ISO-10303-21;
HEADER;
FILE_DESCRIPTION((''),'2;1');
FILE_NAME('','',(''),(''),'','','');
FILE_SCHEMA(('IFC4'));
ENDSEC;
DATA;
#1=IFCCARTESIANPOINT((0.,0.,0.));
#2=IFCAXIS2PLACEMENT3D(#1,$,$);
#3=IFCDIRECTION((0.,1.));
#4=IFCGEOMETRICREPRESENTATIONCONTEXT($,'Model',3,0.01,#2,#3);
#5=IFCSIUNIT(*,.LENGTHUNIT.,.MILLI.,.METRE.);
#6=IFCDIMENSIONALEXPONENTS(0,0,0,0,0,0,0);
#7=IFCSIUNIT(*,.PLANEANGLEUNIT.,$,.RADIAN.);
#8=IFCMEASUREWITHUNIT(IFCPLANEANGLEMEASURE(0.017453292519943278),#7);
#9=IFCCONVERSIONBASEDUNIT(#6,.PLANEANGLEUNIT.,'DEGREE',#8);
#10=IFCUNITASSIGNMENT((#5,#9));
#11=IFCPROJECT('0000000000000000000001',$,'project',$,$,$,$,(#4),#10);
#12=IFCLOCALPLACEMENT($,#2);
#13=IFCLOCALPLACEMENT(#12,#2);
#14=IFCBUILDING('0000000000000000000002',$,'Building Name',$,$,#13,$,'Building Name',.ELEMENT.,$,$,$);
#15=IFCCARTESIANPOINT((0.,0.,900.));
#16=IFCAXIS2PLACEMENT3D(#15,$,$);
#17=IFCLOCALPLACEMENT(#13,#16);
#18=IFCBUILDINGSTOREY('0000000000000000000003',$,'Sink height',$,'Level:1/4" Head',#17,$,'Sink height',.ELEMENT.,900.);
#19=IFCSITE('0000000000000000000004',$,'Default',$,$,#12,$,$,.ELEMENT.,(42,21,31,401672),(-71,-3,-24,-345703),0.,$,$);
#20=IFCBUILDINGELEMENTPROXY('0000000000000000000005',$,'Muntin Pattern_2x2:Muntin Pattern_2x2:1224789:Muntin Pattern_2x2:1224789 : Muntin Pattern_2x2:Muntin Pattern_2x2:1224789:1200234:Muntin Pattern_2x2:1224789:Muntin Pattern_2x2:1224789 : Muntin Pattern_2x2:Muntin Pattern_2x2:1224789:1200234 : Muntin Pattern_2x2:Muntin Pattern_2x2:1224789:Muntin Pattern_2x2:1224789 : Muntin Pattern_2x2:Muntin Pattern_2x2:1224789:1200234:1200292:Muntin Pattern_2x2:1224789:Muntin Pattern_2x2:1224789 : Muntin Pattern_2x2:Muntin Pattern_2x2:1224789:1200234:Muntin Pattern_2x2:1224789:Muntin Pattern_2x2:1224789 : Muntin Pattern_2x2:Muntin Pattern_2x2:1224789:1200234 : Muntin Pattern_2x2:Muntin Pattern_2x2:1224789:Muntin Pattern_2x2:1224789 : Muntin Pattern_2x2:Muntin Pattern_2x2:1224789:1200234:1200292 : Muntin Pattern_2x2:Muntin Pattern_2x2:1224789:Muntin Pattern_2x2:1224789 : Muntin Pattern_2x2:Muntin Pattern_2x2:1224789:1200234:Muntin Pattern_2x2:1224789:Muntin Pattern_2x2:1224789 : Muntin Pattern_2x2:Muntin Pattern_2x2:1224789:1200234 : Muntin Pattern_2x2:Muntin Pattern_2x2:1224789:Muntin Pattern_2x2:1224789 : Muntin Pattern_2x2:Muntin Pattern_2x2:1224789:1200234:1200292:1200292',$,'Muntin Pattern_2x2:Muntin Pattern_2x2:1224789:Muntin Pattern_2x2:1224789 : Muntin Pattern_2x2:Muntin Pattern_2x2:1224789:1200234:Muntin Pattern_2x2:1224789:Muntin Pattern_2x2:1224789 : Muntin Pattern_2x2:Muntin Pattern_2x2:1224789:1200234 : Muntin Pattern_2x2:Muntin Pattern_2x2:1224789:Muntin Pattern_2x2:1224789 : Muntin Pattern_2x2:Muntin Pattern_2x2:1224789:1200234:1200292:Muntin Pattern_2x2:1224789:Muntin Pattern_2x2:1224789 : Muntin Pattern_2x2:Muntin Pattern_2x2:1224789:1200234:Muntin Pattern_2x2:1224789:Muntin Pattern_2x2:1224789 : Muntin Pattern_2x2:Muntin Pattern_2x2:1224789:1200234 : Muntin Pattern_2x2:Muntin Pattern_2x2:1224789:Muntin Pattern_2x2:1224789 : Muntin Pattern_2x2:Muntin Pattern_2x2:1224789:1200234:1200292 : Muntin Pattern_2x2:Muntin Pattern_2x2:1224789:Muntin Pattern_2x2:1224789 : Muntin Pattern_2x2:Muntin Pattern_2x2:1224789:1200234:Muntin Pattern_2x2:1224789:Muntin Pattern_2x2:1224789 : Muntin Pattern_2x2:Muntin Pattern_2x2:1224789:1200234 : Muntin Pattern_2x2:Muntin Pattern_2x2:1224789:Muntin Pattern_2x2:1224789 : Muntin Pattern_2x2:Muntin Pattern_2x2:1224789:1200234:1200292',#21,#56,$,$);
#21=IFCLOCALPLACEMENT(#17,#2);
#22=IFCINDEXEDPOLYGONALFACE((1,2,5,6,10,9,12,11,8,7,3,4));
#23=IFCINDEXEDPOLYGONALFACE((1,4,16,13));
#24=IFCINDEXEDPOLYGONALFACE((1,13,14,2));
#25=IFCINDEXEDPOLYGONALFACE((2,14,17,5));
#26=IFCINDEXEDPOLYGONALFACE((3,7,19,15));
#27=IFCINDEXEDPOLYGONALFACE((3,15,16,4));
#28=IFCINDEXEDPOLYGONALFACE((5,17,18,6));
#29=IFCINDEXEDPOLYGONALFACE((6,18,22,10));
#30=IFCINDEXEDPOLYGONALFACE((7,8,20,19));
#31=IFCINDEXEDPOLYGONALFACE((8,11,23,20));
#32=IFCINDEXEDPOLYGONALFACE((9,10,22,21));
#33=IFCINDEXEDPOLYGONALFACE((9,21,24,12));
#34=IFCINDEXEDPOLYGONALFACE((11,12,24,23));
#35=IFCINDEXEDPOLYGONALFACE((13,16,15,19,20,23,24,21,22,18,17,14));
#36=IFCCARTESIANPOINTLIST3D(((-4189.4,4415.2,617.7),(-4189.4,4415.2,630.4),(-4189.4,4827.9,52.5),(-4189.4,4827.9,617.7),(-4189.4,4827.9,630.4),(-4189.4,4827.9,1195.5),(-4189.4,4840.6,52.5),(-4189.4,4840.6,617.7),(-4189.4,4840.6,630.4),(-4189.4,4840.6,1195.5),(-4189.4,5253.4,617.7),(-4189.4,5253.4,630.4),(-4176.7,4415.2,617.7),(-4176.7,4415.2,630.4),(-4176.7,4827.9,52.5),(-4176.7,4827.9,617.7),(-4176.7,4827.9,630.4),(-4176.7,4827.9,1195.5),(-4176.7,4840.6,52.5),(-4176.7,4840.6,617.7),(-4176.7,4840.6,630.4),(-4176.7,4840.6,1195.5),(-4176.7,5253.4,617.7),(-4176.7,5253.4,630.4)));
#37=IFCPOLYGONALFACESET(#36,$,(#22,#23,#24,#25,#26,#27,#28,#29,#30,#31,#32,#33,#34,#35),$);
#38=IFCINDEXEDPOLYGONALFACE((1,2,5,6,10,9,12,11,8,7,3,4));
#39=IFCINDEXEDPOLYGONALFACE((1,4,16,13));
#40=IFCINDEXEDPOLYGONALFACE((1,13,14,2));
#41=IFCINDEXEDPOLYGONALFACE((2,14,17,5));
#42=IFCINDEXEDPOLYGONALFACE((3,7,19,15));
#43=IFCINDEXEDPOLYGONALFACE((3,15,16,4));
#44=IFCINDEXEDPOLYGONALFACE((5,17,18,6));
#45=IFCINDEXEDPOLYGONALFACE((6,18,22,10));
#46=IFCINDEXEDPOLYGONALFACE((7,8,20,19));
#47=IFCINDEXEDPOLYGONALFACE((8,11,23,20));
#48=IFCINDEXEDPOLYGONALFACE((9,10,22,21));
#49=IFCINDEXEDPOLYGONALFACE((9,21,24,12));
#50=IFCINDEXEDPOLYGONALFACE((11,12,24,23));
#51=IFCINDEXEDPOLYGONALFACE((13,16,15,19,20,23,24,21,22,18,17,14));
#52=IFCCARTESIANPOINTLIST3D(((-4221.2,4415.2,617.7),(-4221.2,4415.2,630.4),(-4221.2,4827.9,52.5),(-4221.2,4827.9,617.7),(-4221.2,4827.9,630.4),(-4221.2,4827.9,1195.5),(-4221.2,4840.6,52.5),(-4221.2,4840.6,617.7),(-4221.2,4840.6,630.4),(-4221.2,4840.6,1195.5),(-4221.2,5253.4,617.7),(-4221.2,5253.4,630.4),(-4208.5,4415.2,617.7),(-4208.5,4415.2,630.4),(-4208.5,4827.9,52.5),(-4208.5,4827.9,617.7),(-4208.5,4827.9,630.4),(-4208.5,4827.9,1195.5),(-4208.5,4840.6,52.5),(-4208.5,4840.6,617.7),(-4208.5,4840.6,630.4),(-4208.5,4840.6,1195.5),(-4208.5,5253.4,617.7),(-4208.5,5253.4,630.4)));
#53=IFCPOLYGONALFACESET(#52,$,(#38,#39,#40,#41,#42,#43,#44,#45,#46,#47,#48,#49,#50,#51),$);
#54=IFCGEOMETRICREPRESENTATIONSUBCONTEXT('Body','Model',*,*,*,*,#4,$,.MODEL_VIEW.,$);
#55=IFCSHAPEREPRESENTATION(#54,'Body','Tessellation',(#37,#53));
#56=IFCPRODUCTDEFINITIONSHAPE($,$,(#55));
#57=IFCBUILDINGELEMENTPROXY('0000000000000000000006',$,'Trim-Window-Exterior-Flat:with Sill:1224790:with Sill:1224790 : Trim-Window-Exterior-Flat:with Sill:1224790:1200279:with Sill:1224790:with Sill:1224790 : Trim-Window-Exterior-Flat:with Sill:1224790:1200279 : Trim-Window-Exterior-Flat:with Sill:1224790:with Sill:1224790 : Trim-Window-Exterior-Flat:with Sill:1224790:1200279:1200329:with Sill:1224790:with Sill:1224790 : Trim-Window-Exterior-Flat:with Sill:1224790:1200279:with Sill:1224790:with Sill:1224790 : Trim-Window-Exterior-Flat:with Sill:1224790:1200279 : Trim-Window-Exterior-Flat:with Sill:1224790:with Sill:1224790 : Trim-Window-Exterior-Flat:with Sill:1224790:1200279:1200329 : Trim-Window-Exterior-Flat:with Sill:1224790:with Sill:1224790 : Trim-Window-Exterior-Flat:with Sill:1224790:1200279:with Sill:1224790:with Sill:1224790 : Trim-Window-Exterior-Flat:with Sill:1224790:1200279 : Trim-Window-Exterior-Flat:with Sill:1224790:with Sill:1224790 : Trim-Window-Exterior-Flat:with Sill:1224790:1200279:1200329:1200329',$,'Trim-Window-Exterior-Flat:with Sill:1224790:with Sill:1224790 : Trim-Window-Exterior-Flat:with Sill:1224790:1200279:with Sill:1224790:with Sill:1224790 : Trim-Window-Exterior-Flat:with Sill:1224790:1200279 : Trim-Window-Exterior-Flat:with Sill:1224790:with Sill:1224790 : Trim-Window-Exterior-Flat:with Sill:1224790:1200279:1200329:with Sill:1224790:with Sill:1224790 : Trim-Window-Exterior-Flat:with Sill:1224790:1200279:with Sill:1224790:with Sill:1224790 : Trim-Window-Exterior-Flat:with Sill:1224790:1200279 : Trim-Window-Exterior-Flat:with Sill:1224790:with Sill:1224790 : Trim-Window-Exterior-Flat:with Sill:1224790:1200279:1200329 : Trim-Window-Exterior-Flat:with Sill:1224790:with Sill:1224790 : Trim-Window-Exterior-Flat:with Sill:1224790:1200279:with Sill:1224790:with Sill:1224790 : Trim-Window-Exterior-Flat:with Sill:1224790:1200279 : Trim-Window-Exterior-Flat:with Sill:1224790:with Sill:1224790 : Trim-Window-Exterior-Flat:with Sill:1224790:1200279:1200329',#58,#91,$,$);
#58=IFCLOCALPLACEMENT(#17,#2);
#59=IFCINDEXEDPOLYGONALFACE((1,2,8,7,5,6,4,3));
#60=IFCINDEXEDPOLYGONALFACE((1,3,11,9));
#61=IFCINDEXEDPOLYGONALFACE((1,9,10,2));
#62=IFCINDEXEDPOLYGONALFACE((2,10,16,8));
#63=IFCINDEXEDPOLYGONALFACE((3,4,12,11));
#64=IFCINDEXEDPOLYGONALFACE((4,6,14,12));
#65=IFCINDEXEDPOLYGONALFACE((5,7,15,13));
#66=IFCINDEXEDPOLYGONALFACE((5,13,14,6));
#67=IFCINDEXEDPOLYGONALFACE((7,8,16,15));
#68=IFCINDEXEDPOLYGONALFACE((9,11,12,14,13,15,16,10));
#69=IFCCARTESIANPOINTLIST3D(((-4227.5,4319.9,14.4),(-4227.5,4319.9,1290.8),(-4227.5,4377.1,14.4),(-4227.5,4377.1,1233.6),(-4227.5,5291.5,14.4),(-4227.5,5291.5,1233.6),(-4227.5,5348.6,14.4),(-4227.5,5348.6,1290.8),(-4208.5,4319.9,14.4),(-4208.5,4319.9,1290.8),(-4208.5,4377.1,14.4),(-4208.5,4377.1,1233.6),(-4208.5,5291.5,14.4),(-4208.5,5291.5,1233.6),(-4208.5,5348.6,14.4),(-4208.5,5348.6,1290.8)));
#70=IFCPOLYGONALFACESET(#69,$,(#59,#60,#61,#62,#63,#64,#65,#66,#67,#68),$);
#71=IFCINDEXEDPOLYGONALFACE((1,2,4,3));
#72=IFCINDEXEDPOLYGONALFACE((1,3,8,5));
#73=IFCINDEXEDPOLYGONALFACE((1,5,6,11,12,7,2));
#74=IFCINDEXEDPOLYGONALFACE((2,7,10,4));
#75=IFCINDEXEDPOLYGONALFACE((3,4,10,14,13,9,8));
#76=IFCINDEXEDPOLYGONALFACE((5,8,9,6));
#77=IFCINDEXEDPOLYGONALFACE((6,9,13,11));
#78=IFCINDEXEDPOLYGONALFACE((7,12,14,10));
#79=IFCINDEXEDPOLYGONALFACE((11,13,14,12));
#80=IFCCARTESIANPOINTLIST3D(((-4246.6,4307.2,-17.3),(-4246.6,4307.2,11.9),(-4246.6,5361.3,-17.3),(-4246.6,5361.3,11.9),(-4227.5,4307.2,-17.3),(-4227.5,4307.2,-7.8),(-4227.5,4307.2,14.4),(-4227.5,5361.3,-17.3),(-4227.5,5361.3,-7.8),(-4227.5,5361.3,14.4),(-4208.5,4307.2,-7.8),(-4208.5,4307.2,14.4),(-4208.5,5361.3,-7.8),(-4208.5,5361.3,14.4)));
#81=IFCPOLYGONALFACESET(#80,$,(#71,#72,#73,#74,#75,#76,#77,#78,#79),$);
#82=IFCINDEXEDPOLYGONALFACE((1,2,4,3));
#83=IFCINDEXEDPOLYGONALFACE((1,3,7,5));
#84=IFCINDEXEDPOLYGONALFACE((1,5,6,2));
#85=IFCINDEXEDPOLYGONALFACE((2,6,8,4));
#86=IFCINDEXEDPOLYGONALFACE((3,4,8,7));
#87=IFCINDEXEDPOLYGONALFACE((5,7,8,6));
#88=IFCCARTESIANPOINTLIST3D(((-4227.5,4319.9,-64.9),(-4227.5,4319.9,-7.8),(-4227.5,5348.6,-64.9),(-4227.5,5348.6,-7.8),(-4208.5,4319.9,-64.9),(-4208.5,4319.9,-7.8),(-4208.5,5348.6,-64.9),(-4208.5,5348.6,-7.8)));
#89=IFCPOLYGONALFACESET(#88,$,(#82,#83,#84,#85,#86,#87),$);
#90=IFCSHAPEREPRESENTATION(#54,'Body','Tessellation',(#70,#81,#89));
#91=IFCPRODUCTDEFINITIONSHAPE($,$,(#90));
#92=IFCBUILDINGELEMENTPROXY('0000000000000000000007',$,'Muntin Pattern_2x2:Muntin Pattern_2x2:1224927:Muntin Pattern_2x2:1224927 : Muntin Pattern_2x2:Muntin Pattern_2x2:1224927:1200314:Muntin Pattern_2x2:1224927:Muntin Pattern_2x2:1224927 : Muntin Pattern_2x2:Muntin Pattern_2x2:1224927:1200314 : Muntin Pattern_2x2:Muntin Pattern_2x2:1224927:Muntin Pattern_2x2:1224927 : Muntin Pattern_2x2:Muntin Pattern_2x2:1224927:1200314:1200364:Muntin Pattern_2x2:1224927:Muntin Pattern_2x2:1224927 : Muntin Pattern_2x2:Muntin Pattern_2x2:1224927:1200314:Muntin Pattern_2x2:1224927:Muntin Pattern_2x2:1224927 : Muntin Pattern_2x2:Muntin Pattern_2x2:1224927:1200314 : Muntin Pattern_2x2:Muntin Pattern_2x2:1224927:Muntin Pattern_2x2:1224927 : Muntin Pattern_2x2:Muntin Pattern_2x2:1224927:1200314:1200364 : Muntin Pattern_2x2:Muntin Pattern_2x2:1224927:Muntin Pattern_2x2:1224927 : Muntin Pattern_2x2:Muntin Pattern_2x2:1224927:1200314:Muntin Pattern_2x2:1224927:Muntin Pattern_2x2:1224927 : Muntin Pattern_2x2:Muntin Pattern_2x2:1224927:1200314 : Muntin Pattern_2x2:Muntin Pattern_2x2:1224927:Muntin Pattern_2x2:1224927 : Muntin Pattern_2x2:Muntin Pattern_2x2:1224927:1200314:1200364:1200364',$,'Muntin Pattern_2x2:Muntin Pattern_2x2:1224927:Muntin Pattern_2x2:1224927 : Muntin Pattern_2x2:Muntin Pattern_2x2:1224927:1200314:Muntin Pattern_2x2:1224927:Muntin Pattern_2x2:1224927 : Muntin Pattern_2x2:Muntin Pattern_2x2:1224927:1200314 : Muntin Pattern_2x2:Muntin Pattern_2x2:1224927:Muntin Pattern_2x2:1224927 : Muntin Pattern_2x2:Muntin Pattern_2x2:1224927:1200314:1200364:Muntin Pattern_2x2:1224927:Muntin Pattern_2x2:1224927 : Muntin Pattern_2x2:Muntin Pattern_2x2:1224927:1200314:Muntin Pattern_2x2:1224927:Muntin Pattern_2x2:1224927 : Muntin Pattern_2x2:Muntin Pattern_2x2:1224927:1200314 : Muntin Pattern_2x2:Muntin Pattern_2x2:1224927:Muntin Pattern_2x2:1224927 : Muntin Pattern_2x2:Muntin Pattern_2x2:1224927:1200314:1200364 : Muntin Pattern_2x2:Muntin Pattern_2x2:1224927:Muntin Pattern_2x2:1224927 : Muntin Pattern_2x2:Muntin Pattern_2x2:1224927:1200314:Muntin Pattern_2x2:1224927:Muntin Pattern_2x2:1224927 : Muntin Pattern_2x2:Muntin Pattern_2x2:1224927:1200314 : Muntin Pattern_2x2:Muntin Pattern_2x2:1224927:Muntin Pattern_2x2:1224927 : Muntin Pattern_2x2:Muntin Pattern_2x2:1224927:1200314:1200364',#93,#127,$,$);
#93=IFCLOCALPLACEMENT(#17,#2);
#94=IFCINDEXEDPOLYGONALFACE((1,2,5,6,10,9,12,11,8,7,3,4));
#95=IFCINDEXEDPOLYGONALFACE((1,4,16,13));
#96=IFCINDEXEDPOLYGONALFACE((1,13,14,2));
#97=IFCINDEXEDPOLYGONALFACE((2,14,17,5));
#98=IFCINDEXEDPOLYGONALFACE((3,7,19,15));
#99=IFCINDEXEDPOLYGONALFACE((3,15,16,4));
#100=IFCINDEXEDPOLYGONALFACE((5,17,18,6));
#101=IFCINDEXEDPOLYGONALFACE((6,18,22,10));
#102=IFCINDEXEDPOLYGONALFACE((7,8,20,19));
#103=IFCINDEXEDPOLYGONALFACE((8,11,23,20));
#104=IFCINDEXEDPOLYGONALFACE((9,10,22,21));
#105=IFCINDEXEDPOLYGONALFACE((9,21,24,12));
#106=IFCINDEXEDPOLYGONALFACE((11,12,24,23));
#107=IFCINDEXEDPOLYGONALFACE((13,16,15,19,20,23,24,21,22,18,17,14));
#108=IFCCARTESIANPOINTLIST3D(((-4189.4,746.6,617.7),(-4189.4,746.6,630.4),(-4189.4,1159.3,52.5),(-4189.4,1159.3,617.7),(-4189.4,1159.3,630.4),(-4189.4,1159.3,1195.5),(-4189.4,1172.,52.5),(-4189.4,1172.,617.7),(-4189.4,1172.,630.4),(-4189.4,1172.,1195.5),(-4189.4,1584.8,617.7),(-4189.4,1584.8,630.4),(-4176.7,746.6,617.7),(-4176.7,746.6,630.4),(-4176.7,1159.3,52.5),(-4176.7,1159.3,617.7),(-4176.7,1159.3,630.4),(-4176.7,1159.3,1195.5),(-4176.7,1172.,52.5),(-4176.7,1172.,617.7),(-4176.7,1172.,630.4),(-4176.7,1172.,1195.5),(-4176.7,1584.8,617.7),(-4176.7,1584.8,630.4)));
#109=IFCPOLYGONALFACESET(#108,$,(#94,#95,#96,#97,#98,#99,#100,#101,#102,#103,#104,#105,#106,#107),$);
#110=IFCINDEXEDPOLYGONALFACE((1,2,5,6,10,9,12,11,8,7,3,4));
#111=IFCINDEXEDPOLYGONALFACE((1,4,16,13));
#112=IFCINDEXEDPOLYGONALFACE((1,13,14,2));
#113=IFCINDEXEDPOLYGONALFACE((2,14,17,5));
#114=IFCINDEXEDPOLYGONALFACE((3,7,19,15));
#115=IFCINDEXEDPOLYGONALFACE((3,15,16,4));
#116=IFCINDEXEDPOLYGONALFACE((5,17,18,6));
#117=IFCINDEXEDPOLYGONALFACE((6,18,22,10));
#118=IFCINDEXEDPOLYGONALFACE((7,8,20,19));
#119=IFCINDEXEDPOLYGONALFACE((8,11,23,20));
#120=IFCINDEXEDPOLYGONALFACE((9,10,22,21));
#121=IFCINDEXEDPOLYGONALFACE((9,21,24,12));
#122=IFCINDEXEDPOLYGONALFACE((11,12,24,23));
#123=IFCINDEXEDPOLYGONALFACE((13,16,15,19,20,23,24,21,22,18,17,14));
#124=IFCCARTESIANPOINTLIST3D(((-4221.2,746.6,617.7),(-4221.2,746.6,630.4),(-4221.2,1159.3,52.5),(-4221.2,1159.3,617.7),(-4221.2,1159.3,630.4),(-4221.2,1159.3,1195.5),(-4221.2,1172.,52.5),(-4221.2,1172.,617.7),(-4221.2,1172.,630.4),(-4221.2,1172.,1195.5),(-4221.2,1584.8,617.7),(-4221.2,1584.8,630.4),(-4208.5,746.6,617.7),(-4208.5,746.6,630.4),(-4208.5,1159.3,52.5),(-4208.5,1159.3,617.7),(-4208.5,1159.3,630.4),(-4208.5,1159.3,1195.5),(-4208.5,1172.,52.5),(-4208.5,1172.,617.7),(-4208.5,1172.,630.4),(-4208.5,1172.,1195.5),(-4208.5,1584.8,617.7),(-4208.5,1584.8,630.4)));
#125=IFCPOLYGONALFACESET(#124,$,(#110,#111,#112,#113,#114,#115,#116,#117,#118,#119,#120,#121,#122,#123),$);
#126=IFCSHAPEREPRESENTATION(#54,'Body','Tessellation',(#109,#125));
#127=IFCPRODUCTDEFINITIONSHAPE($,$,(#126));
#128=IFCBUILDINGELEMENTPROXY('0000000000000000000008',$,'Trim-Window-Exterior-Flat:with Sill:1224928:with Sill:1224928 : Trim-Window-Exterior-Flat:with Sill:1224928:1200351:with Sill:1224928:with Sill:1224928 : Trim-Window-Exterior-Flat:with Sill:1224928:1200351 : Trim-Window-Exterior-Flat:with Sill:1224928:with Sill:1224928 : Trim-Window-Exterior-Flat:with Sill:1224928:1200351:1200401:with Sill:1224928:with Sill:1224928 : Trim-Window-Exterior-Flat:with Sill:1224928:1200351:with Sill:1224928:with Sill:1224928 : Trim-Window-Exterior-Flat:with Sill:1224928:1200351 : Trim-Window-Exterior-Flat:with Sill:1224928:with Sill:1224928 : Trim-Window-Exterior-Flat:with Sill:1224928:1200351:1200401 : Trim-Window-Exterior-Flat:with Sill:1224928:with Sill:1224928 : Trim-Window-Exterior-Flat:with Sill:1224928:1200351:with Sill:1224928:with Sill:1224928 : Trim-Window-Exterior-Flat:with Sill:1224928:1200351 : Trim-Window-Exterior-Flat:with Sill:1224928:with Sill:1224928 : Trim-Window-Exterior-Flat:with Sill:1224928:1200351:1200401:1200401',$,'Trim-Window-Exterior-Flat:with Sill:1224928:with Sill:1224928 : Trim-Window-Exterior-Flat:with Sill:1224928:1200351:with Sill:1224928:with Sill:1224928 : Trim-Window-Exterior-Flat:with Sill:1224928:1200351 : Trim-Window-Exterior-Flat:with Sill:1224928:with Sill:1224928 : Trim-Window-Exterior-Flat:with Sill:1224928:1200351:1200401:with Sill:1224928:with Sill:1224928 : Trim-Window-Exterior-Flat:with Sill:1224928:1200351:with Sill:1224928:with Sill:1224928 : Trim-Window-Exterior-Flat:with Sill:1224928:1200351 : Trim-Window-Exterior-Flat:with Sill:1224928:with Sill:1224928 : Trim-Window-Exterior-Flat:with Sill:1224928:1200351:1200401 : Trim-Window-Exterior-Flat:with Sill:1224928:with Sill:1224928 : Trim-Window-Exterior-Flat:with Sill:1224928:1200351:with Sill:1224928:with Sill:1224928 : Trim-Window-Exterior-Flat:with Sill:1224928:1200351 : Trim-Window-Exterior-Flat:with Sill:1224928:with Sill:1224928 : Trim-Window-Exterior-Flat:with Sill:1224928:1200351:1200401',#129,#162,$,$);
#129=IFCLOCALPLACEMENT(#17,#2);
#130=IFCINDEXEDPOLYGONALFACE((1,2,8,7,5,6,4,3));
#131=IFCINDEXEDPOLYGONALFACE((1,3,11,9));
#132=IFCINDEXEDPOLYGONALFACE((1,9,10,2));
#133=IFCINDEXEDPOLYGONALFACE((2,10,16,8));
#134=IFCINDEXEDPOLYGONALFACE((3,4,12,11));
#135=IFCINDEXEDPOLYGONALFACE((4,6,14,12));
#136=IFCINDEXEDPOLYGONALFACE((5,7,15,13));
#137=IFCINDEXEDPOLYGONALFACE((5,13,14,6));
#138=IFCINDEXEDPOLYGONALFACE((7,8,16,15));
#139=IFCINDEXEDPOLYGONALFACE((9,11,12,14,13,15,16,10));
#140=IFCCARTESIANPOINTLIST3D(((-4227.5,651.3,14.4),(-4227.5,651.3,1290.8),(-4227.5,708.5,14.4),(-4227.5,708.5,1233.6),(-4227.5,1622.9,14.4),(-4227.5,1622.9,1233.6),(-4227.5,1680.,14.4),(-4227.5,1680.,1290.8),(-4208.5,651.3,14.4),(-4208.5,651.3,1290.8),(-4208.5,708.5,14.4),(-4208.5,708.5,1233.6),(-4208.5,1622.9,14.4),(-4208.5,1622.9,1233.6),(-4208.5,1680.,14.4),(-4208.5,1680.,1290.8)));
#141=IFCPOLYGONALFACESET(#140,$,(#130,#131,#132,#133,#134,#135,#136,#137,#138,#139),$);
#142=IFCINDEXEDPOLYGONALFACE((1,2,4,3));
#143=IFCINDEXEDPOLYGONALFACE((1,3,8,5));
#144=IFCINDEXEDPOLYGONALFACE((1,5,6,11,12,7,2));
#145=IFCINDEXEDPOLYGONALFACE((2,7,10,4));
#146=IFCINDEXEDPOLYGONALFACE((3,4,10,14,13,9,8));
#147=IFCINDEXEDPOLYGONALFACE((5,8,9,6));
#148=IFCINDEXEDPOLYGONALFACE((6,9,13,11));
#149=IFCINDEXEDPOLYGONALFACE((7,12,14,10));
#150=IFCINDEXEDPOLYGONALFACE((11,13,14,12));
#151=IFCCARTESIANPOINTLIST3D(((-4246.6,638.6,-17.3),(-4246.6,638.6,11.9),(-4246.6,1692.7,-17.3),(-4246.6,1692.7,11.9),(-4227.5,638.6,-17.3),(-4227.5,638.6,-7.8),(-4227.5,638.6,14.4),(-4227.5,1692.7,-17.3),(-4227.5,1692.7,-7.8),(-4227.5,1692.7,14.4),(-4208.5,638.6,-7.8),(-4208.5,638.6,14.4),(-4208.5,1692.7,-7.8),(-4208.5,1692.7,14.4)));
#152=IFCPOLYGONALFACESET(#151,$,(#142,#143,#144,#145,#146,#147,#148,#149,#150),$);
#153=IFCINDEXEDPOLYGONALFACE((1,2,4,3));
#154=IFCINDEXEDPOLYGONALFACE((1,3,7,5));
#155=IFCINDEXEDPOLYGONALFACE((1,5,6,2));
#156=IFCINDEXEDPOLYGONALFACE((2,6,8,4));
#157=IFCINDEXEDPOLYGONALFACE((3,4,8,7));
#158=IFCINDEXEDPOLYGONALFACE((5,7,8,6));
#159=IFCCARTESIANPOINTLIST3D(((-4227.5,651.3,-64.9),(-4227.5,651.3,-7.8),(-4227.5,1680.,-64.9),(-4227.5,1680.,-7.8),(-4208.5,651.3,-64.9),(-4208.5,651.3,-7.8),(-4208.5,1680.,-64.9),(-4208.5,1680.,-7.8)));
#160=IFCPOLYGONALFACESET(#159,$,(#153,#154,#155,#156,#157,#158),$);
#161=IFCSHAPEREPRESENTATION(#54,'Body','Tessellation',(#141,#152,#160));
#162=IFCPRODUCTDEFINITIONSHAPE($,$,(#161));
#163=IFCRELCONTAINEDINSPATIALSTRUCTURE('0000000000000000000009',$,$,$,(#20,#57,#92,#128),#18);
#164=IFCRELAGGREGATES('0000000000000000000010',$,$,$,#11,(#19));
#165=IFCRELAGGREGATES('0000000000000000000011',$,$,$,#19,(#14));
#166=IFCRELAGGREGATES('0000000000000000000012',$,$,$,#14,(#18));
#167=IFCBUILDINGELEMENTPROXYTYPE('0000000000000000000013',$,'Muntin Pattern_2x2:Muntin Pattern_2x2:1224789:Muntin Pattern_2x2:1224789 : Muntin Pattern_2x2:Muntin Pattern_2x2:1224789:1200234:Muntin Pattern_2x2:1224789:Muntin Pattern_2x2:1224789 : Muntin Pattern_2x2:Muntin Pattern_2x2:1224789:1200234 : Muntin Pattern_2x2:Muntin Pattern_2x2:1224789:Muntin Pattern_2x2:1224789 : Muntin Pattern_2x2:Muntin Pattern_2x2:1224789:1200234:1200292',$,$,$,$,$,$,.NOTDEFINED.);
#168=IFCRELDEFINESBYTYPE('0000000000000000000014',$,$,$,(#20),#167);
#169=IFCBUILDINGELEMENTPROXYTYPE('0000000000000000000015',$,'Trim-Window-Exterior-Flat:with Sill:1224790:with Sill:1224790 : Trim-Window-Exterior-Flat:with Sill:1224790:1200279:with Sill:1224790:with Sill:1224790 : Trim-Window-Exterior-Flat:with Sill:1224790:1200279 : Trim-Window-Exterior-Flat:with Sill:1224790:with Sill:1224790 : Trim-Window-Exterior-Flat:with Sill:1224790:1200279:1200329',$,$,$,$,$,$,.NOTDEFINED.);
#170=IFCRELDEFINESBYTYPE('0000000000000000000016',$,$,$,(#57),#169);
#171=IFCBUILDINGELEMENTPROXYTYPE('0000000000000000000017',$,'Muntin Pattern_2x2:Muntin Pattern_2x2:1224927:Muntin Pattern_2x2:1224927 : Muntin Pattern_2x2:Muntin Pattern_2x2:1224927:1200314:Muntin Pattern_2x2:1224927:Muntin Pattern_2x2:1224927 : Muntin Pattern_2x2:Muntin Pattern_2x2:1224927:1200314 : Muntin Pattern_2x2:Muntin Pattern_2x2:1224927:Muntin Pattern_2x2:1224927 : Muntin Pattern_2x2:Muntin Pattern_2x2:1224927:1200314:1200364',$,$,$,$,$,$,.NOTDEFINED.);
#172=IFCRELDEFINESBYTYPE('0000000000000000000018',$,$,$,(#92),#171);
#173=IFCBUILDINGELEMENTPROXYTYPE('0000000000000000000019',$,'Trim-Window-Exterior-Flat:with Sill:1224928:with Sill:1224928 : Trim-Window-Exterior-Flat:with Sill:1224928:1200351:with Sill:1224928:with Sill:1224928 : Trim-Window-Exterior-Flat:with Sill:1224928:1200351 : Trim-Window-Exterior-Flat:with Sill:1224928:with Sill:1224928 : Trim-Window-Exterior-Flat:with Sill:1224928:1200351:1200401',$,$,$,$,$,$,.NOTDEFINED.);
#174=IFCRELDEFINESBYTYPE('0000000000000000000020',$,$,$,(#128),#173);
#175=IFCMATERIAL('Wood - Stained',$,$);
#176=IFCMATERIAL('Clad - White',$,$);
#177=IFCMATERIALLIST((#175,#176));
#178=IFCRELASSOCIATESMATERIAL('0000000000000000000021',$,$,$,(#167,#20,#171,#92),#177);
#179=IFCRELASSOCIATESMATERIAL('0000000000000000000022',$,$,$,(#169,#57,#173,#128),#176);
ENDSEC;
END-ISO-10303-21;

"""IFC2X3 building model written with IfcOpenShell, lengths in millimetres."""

from ifc_helpers import new_model, entity, si_unit, converted_unit, direction, frame, frame_2d, origin, place, context, subcontext, project, spatial, polyline, rectangle, outline, extrude, source, transform, mapped, material, material_list, type_object, type_shapes, element, save


model = new_model("IFC2X3")

# Units and contexts
model_context = context("Model", 3, precision=0.01, world=origin(), true_north=direction((0.0, 1.0)))
body_context = subcontext(model_context, "Body", "Model", "MODEL_VIEW")
ifc_project = project(units=[si_unit("LENGTHUNIT", "METRE", prefix="MILLI"), converted_unit("PLANEANGLEUNIT", "DEGREE", entity("IfcPlaneAngleMeasure", 0.017453292519943278), si_unit("PLANEANGLEUNIT", "RADIAN"), dimensions=[0, 0, 0, 0, 0, 0, 0])], contexts=[model_context])

# Site, building, storey
site_placement = place(None, origin())
site = spatial("IfcSite", under=ifc_project, at=site_placement, Name="Default", CompositionType="ELEMENT", RefLatitude=(42, 21, 31, 401672), RefLongitude=(-71, -3, -24, -345703), RefElevation=0.0)
building_placement = place(site_placement, origin())
building = spatial("IfcBuilding", under=site, at=building_placement, Name="Building Name", LongName="Building Name", CompositionType="ELEMENT")
storey_placement = place(building_placement, frame((0.0, 0.0, 900.0)))
storey = spatial("IfcBuildingStorey", under=building, at=storey_placement, Name="Sink height", ObjectType="Level:1/4\" Head", LongName="Sink height", CompositionType="ELEMENT", Elevation=900.0)

# Building element proxies
ifc_material_1 = material(Name="Wood - Stained")
ifc_material_2 = material(Name="Clad - White")
ifc_material_list = material_list([ifc_material_1, ifc_material_2])
building_element_proxy_type_1 = type_object("IfcBuildingElementProxyType", Name="Muntin Pattern_2x2:Muntin Pattern_2x2:1224789:Muntin Pattern_2x2:1224789 : Muntin Pattern_2x2:Muntin Pattern_2x2:1224789:1200234:Muntin Pattern_2x2:1224789:Muntin Pattern_2x2:1224789 : Muntin Pattern_2x2:Muntin Pattern_2x2:1224789:1200234 : Muntin Pattern_2x2:Muntin Pattern_2x2:1224789:Muntin Pattern_2x2:1224789 : Muntin Pattern_2x2:Muntin Pattern_2x2:1224789:1200234:1200292", PredefinedType="NOTDEFINED", material=ifc_material_list)
shared_shape_1 = source(origin(), body_context, "Body", "SweptSolid", [
    extrude(outline(polyline([(6.3, -6.4), (419.1, -6.4), (419.1, 6.3), (6.3, 6.3), (6.3, 571.5), (-6.4, 571.5), (-6.4, 6.3), (-419.1, 6.3), (-419.1, -6.4), (-6.4, -6.4), (-6.4, -571.5), (6.3, -571.5), (6.3, -6.4)])), frame((-4189.4, 4834.3, 1524.0), z_axis=(1.0, 0.0, 0.0), x_axis=(0.0, -1.0, 0.0)), (0.0, 0.0, 1.0), 12.7),
    extrude(outline(polyline([(6.3, -6.4), (419.1, -6.4), (419.1, 6.3), (6.3, 6.3), (6.3, 571.5), (-6.4, 571.5), (-6.4, 6.3), (-419.1, 6.3), (-419.1, -6.4), (-6.4, -6.4), (-6.4, -571.5), (6.3, -571.5), (6.3, -6.4)])), frame((-4221.2, 4834.3, 1524.0), z_axis=(1.0, 0.0, 0.0), x_axis=(0.0, -1.0, 0.0)), (0.0, 0.0, 1.0), 12.7),
])
type_shapes(building_element_proxy_type_1, [shared_shape_1])
proxy_1_placement = place(storey_placement, frame((0.0, 0.0, -900.0)))
element("IfcBuildingElementProxy", 1, at=proxy_1_placement, inside=storey, type_object=building_element_proxy_type_1, material=ifc_material_list, Name="Muntin Pattern_2x2:Muntin Pattern_2x2:1224789:Muntin Pattern_2x2:1224789 : Muntin Pattern_2x2:Muntin Pattern_2x2:1224789:1200234:Muntin Pattern_2x2:1224789:Muntin Pattern_2x2:1224789 : Muntin Pattern_2x2:Muntin Pattern_2x2:1224789:1200234 : Muntin Pattern_2x2:Muntin Pattern_2x2:1224789:Muntin Pattern_2x2:1224789 : Muntin Pattern_2x2:Muntin Pattern_2x2:1224789:1200234:1200292:Muntin Pattern_2x2:1224789:Muntin Pattern_2x2:1224789 : Muntin Pattern_2x2:Muntin Pattern_2x2:1224789:1200234:Muntin Pattern_2x2:1224789:Muntin Pattern_2x2:1224789 : Muntin Pattern_2x2:Muntin Pattern_2x2:1224789:1200234 : Muntin Pattern_2x2:Muntin Pattern_2x2:1224789:Muntin Pattern_2x2:1224789 : Muntin Pattern_2x2:Muntin Pattern_2x2:1224789:1200234:1200292 : Muntin Pattern_2x2:Muntin Pattern_2x2:1224789:Muntin Pattern_2x2:1224789 : Muntin Pattern_2x2:Muntin Pattern_2x2:1224789:1200234:Muntin Pattern_2x2:1224789:Muntin Pattern_2x2:1224789 : Muntin Pattern_2x2:Muntin Pattern_2x2:1224789:1200234 : Muntin Pattern_2x2:Muntin Pattern_2x2:1224789:Muntin Pattern_2x2:1224789 : Muntin Pattern_2x2:Muntin Pattern_2x2:1224789:1200234:1200292:1200292", ObjectType="Muntin Pattern_2x2:Muntin Pattern_2x2:1224789:Muntin Pattern_2x2:1224789 : Muntin Pattern_2x2:Muntin Pattern_2x2:1224789:1200234:Muntin Pattern_2x2:1224789:Muntin Pattern_2x2:1224789 : Muntin Pattern_2x2:Muntin Pattern_2x2:1224789:1200234 : Muntin Pattern_2x2:Muntin Pattern_2x2:1224789:Muntin Pattern_2x2:1224789 : Muntin Pattern_2x2:Muntin Pattern_2x2:1224789:1200234:1200292:Muntin Pattern_2x2:1224789:Muntin Pattern_2x2:1224789 : Muntin Pattern_2x2:Muntin Pattern_2x2:1224789:1200234:Muntin Pattern_2x2:1224789:Muntin Pattern_2x2:1224789 : Muntin Pattern_2x2:Muntin Pattern_2x2:1224789:1200234 : Muntin Pattern_2x2:Muntin Pattern_2x2:1224789:Muntin Pattern_2x2:1224789 : Muntin Pattern_2x2:Muntin Pattern_2x2:1224789:1200234:1200292 : Muntin Pattern_2x2:Muntin Pattern_2x2:1224789:Muntin Pattern_2x2:1224789 : Muntin Pattern_2x2:Muntin Pattern_2x2:1224789:1200234:Muntin Pattern_2x2:1224789:Muntin Pattern_2x2:1224789 : Muntin Pattern_2x2:Muntin Pattern_2x2:1224789:1200234 : Muntin Pattern_2x2:Muntin Pattern_2x2:1224789:Muntin Pattern_2x2:1224789 : Muntin Pattern_2x2:Muntin Pattern_2x2:1224789:1200234:1200292", context=body_context, shape_type="MappedRepresentation", body=[
    mapped(shared_shape_1, transform((0.0, 0.0, 0.0), scale=1.0)),
])
building_element_proxy_type_2 = type_object("IfcBuildingElementProxyType", Name="Trim-Window-Exterior-Flat:with Sill:1224790:with Sill:1224790 : Trim-Window-Exterior-Flat:with Sill:1224790:1200279:with Sill:1224790:with Sill:1224790 : Trim-Window-Exterior-Flat:with Sill:1224790:1200279 : Trim-Window-Exterior-Flat:with Sill:1224790:with Sill:1224790 : Trim-Window-Exterior-Flat:with Sill:1224790:1200279:1200329", PredefinedType="NOTDEFINED", material=ifc_material_2)
shared_shape_2 = source(origin(), body_context, "Body", "SweptSolid", [
    extrude(outline(polyline([(-652.5, -514.3), (623.9, -514.3), (623.9, -457.2), (-595.3, -457.2), (-595.3, 457.2), (623.9, 457.2), (623.9, 514.4), (-652.5, 514.4), (-652.5, -514.3)])), frame((-4227.5, 4834.3, 1538.3), z_axis=(1.0, 0.0, 0.0), x_axis=(0.0, 0.0, -1.0)), (0.0, 0.0, 1.0), 19.1),
    extrude(outline(polyline([(-17.2, -15.6), (2.0, -15.6), (20.9, -13.2), (18.1, 8.8), (-0.8, 6.4), (-2.0, 15.9), (-20.9, 13.4), (-17.2, -15.6)])), frame((-4227.5, 4307.2, 898.6), z_axis=(0.0, 1.0, 0.0), x_axis=(0.991778, 0.0, 0.127971)), (0.0, 0.0, 1.0), 1054.1),
    extrude(rectangle(XDim=19.0, YDim=1028.7, at=frame_2d((0.0, 0.0), x_axis=(1.0, 0.0))), frame((-4218.0, 4834.3, 835.1), z_axis=(0.0, 0.0, 1.0), x_axis=(-1.0, 0.0, 0.0)), (0.0, 0.0, 1.0), 57.2),
])
type_shapes(building_element_proxy_type_2, [shared_shape_2])
proxy_2_placement = place(storey_placement, frame((0.0, 0.0, -900.0)))
element("IfcBuildingElementProxy", 2, at=proxy_2_placement, inside=storey, type_object=building_element_proxy_type_2, material=ifc_material_2, Name="Trim-Window-Exterior-Flat:with Sill:1224790:with Sill:1224790 : Trim-Window-Exterior-Flat:with Sill:1224790:1200279:with Sill:1224790:with Sill:1224790 : Trim-Window-Exterior-Flat:with Sill:1224790:1200279 : Trim-Window-Exterior-Flat:with Sill:1224790:with Sill:1224790 : Trim-Window-Exterior-Flat:with Sill:1224790:1200279:1200329:with Sill:1224790:with Sill:1224790 : Trim-Window-Exterior-Flat:with Sill:1224790:1200279:with Sill:1224790:with Sill:1224790 : Trim-Window-Exterior-Flat:with Sill:1224790:1200279 : Trim-Window-Exterior-Flat:with Sill:1224790:with Sill:1224790 : Trim-Window-Exterior-Flat:with Sill:1224790:1200279:1200329 : Trim-Window-Exterior-Flat:with Sill:1224790:with Sill:1224790 : Trim-Window-Exterior-Flat:with Sill:1224790:1200279:with Sill:1224790:with Sill:1224790 : Trim-Window-Exterior-Flat:with Sill:1224790:1200279 : Trim-Window-Exterior-Flat:with Sill:1224790:with Sill:1224790 : Trim-Window-Exterior-Flat:with Sill:1224790:1200279:1200329:1200329", ObjectType="Trim-Window-Exterior-Flat:with Sill:1224790:with Sill:1224790 : Trim-Window-Exterior-Flat:with Sill:1224790:1200279:with Sill:1224790:with Sill:1224790 : Trim-Window-Exterior-Flat:with Sill:1224790:1200279 : Trim-Window-Exterior-Flat:with Sill:1224790:with Sill:1224790 : Trim-Window-Exterior-Flat:with Sill:1224790:1200279:1200329:with Sill:1224790:with Sill:1224790 : Trim-Window-Exterior-Flat:with Sill:1224790:1200279:with Sill:1224790:with Sill:1224790 : Trim-Window-Exterior-Flat:with Sill:1224790:1200279 : Trim-Window-Exterior-Flat:with Sill:1224790:with Sill:1224790 : Trim-Window-Exterior-Flat:with Sill:1224790:1200279:1200329 : Trim-Window-Exterior-Flat:with Sill:1224790:with Sill:1224790 : Trim-Window-Exterior-Flat:with Sill:1224790:1200279:with Sill:1224790:with Sill:1224790 : Trim-Window-Exterior-Flat:with Sill:1224790:1200279 : Trim-Window-Exterior-Flat:with Sill:1224790:with Sill:1224790 : Trim-Window-Exterior-Flat:with Sill:1224790:1200279:1200329", context=body_context, shape_type="MappedRepresentation", body=[
    mapped(shared_shape_2, transform((0.0, 0.0, 0.0), scale=1.0)),
])
building_element_proxy_type_3 = type_object("IfcBuildingElementProxyType", Name="Muntin Pattern_2x2:Muntin Pattern_2x2:1224927:Muntin Pattern_2x2:1224927 : Muntin Pattern_2x2:Muntin Pattern_2x2:1224927:1200314:Muntin Pattern_2x2:1224927:Muntin Pattern_2x2:1224927 : Muntin Pattern_2x2:Muntin Pattern_2x2:1224927:1200314 : Muntin Pattern_2x2:Muntin Pattern_2x2:1224927:Muntin Pattern_2x2:1224927 : Muntin Pattern_2x2:Muntin Pattern_2x2:1224927:1200314:1200364", PredefinedType="NOTDEFINED", material=ifc_material_list)
shared_shape_3 = source(origin(), body_context, "Body", "SweptSolid", [
    extrude(outline(polyline([(6.3, -6.4), (419.1, -6.4), (419.1, 6.3), (6.3, 6.3), (6.3, 571.5), (-6.4, 571.5), (-6.4, 6.3), (-419.1, 6.3), (-419.1, -6.4), (-6.4, -6.4), (-6.4, -571.5), (6.3, -571.5), (6.3, -6.4)])), frame((-4189.4, 1165.7, 1524.0), z_axis=(1.0, 0.0, 0.0), x_axis=(0.0, -1.0, 0.0)), (0.0, 0.0, 1.0), 12.7),
    extrude(outline(polyline([(6.3, -6.4), (419.1, -6.4), (419.1, 6.3), (6.3, 6.3), (6.3, 571.5), (-6.4, 571.5), (-6.4, 6.3), (-419.1, 6.3), (-419.1, -6.4), (-6.4, -6.4), (-6.4, -571.5), (6.3, -571.5), (6.3, -6.4)])), frame((-4221.2, 1165.7, 1524.0), z_axis=(1.0, 0.0, 0.0), x_axis=(0.0, -1.0, 0.0)), (0.0, 0.0, 1.0), 12.7),
])
type_shapes(building_element_proxy_type_3, [shared_shape_3])
proxy_3_placement = place(storey_placement, frame((0.0, 0.0, -900.0)))
element("IfcBuildingElementProxy", 3, at=proxy_3_placement, inside=storey, type_object=building_element_proxy_type_3, material=ifc_material_list, Name="Muntin Pattern_2x2:Muntin Pattern_2x2:1224927:Muntin Pattern_2x2:1224927 : Muntin Pattern_2x2:Muntin Pattern_2x2:1224927:1200314:Muntin Pattern_2x2:1224927:Muntin Pattern_2x2:1224927 : Muntin Pattern_2x2:Muntin Pattern_2x2:1224927:1200314 : Muntin Pattern_2x2:Muntin Pattern_2x2:1224927:Muntin Pattern_2x2:1224927 : Muntin Pattern_2x2:Muntin Pattern_2x2:1224927:1200314:1200364:Muntin Pattern_2x2:1224927:Muntin Pattern_2x2:1224927 : Muntin Pattern_2x2:Muntin Pattern_2x2:1224927:1200314:Muntin Pattern_2x2:1224927:Muntin Pattern_2x2:1224927 : Muntin Pattern_2x2:Muntin Pattern_2x2:1224927:1200314 : Muntin Pattern_2x2:Muntin Pattern_2x2:1224927:Muntin Pattern_2x2:1224927 : Muntin Pattern_2x2:Muntin Pattern_2x2:1224927:1200314:1200364 : Muntin Pattern_2x2:Muntin Pattern_2x2:1224927:Muntin Pattern_2x2:1224927 : Muntin Pattern_2x2:Muntin Pattern_2x2:1224927:1200314:Muntin Pattern_2x2:1224927:Muntin Pattern_2x2:1224927 : Muntin Pattern_2x2:Muntin Pattern_2x2:1224927:1200314 : Muntin Pattern_2x2:Muntin Pattern_2x2:1224927:Muntin Pattern_2x2:1224927 : Muntin Pattern_2x2:Muntin Pattern_2x2:1224927:1200314:1200364:1200364", ObjectType="Muntin Pattern_2x2:Muntin Pattern_2x2:1224927:Muntin Pattern_2x2:1224927 : Muntin Pattern_2x2:Muntin Pattern_2x2:1224927:1200314:Muntin Pattern_2x2:1224927:Muntin Pattern_2x2:1224927 : Muntin Pattern_2x2:Muntin Pattern_2x2:1224927:1200314 : Muntin Pattern_2x2:Muntin Pattern_2x2:1224927:Muntin Pattern_2x2:1224927 : Muntin Pattern_2x2:Muntin Pattern_2x2:1224927:1200314:1200364:Muntin Pattern_2x2:1224927:Muntin Pattern_2x2:1224927 : Muntin Pattern_2x2:Muntin Pattern_2x2:1224927:1200314:Muntin Pattern_2x2:1224927:Muntin Pattern_2x2:1224927 : Muntin Pattern_2x2:Muntin Pattern_2x2:1224927:1200314 : Muntin Pattern_2x2:Muntin Pattern_2x2:1224927:Muntin Pattern_2x2:1224927 : Muntin Pattern_2x2:Muntin Pattern_2x2:1224927:1200314:1200364 : Muntin Pattern_2x2:Muntin Pattern_2x2:1224927:Muntin Pattern_2x2:1224927 : Muntin Pattern_2x2:Muntin Pattern_2x2:1224927:1200314:Muntin Pattern_2x2:1224927:Muntin Pattern_2x2:1224927 : Muntin Pattern_2x2:Muntin Pattern_2x2:1224927:1200314 : Muntin Pattern_2x2:Muntin Pattern_2x2:1224927:Muntin Pattern_2x2:1224927 : Muntin Pattern_2x2:Muntin Pattern_2x2:1224927:1200314:1200364", context=body_context, shape_type="MappedRepresentation", body=[
    mapped(shared_shape_3, transform((0.0, 0.0, 0.0), scale=1.0)),
])
building_element_proxy_type_4 = type_object("IfcBuildingElementProxyType", Name="Trim-Window-Exterior-Flat:with Sill:1224928:with Sill:1224928 : Trim-Window-Exterior-Flat:with Sill:1224928:1200351:with Sill:1224928:with Sill:1224928 : Trim-Window-Exterior-Flat:with Sill:1224928:1200351 : Trim-Window-Exterior-Flat:with Sill:1224928:with Sill:1224928 : Trim-Window-Exterior-Flat:with Sill:1224928:1200351:1200401", PredefinedType="NOTDEFINED", material=ifc_material_2)
shared_shape_4 = source(origin(), body_context, "Body", "SweptSolid", [
    extrude(outline(polyline([(-652.5, -514.3), (623.9, -514.3), (623.9, -457.2), (-595.3, -457.2), (-595.3, 457.2), (623.9, 457.2), (623.9, 514.4), (-652.5, 514.4), (-652.5, -514.3)])), frame((-4227.5, 1165.7, 1538.3), z_axis=(1.0, 0.0, 0.0), x_axis=(0.0, 0.0, -1.0)), (0.0, 0.0, 1.0), 19.1),
    extrude(outline(polyline([(-17.2, -15.6), (2.0, -15.6), (20.9, -13.2), (18.1, 8.8), (-0.8, 6.4), (-2.0, 15.9), (-20.9, 13.4), (-17.2, -15.6)])), frame((-4227.5, 638.6, 898.6), z_axis=(0.0, 1.0, 0.0), x_axis=(0.991778, 0.0, 0.127971)), (0.0, 0.0, 1.0), 1054.1),
    extrude(rectangle(XDim=19.0, YDim=1028.7, at=frame_2d((0.0, 0.0), x_axis=(1.0, 0.0))), frame((-4218.0, 1165.7, 835.1), z_axis=(0.0, 0.0, 1.0), x_axis=(-1.0, 0.0, 0.0)), (0.0, 0.0, 1.0), 57.2),
])
type_shapes(building_element_proxy_type_4, [shared_shape_4])
proxy_4_placement = place(storey_placement, frame((0.0, 0.0, -900.0)))
element("IfcBuildingElementProxy", 4, at=proxy_4_placement, inside=storey, type_object=building_element_proxy_type_4, material=ifc_material_2, Name="Trim-Window-Exterior-Flat:with Sill:1224928:with Sill:1224928 : Trim-Window-Exterior-Flat:with Sill:1224928:1200351:with Sill:1224928:with Sill:1224928 : Trim-Window-Exterior-Flat:with Sill:1224928:1200351 : Trim-Window-Exterior-Flat:with Sill:1224928:with Sill:1224928 : Trim-Window-Exterior-Flat:with Sill:1224928:1200351:1200401:with Sill:1224928:with Sill:1224928 : Trim-Window-Exterior-Flat:with Sill:1224928:1200351:with Sill:1224928:with Sill:1224928 : Trim-Window-Exterior-Flat:with Sill:1224928:1200351 : Trim-Window-Exterior-Flat:with Sill:1224928:with Sill:1224928 : Trim-Window-Exterior-Flat:with Sill:1224928:1200351:1200401 : Trim-Window-Exterior-Flat:with Sill:1224928:with Sill:1224928 : Trim-Window-Exterior-Flat:with Sill:1224928:1200351:with Sill:1224928:with Sill:1224928 : Trim-Window-Exterior-Flat:with Sill:1224928:1200351 : Trim-Window-Exterior-Flat:with Sill:1224928:with Sill:1224928 : Trim-Window-Exterior-Flat:with Sill:1224928:1200351:1200401:1200401", ObjectType="Trim-Window-Exterior-Flat:with Sill:1224928:with Sill:1224928 : Trim-Window-Exterior-Flat:with Sill:1224928:1200351:with Sill:1224928:with Sill:1224928 : Trim-Window-Exterior-Flat:with Sill:1224928:1200351 : Trim-Window-Exterior-Flat:with Sill:1224928:with Sill:1224928 : Trim-Window-Exterior-Flat:with Sill:1224928:1200351:1200401:with Sill:1224928:with Sill:1224928 : Trim-Window-Exterior-Flat:with Sill:1224928:1200351:with Sill:1224928:with Sill:1224928 : Trim-Window-Exterior-Flat:with Sill:1224928:1200351 : Trim-Window-Exterior-Flat:with Sill:1224928:with Sill:1224928 : Trim-Window-Exterior-Flat:with Sill:1224928:1200351:1200401 : Trim-Window-Exterior-Flat:with Sill:1224928:with Sill:1224928 : Trim-Window-Exterior-Flat:with Sill:1224928:1200351:with Sill:1224928:with Sill:1224928 : Trim-Window-Exterior-Flat:with Sill:1224928:1200351 : Trim-Window-Exterior-Flat:with Sill:1224928:with Sill:1224928 : Trim-Window-Exterior-Flat:with Sill:1224928:1200351:1200401", context=body_context, shape_type="MappedRepresentation", body=[
    mapped(shared_shape_4, transform((0.0, 0.0, 0.0), scale=1.0)),
])

save(model, "model.ifc")
